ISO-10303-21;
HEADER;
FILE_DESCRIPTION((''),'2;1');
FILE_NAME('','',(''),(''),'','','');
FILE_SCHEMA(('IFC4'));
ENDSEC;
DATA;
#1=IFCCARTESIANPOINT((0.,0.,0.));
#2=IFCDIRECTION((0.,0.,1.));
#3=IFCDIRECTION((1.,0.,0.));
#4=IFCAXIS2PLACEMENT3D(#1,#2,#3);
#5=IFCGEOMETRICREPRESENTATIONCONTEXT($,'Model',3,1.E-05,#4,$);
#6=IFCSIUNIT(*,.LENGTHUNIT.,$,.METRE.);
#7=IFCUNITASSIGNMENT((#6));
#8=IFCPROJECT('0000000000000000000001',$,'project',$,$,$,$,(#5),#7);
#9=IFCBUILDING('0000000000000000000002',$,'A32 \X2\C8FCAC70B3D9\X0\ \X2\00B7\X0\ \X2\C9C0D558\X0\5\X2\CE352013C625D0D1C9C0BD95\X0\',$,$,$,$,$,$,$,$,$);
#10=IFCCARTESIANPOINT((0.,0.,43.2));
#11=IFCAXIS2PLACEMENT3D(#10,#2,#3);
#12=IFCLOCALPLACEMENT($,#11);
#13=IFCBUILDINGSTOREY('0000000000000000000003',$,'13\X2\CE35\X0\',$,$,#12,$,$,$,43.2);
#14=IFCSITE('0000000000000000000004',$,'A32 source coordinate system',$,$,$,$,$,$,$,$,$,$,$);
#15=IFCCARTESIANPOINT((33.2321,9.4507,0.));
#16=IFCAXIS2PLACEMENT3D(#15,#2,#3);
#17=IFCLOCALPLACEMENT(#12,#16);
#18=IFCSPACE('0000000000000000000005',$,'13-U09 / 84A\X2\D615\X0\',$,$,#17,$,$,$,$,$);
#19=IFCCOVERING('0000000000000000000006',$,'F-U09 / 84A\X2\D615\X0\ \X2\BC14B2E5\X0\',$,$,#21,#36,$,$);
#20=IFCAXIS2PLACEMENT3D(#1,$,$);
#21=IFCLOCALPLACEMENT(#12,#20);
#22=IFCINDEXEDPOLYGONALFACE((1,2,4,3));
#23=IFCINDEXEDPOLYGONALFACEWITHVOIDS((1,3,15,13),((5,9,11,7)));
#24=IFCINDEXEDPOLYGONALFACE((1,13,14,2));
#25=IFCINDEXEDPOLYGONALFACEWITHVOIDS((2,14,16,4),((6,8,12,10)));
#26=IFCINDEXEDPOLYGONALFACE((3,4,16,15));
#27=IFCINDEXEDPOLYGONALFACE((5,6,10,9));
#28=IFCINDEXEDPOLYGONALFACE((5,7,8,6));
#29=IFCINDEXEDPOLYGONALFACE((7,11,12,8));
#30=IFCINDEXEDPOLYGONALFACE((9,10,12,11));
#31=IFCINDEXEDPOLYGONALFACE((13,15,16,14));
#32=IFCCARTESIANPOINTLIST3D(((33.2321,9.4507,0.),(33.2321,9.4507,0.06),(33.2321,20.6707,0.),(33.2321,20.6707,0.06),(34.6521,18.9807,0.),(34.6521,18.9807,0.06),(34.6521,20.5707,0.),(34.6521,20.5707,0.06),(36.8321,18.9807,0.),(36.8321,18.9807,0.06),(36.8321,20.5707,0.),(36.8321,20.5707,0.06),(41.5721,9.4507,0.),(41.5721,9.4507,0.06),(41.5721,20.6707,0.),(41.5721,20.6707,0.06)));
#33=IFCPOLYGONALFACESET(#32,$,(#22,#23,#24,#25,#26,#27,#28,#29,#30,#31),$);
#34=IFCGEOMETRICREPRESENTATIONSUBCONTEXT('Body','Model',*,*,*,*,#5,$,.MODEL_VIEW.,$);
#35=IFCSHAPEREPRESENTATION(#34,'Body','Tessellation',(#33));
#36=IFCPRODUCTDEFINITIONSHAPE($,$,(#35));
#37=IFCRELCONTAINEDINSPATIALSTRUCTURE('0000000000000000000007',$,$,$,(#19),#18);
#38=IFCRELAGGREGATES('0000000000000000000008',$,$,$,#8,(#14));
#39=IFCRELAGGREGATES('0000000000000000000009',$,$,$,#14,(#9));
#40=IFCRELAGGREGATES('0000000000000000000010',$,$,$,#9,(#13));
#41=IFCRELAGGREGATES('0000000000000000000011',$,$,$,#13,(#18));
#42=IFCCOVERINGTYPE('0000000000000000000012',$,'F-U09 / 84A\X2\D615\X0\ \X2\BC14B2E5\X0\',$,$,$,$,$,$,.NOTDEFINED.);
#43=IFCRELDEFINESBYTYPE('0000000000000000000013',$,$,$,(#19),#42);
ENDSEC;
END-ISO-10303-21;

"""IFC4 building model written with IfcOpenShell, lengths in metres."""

from ifc_helpers import new_model, si_unit, frame, origin, origin_with_axes, place, context, subcontext, project, spatial, polyline, outline, extrude, source, transform, mapped, type_object, type_shapes, element, save


model = new_model("IFC4")

# Units and contexts
model_context = context("Model", 3, precision=1e-05, world=origin_with_axes())
body_context = subcontext(model_context, "Body", "Model", "MODEL_VIEW")
ifc_project = project(units=[si_unit("LENGTHUNIT", "METRE")], contexts=[model_context])

# Site, building, storey, space
storey_placement = place(None, frame((0.0, 0.0, 43.2), z_axis=(0.0, 0.0, 1.0), x_axis=(1.0, 0.0, 0.0)))
space_placement = place(storey_placement, frame((33.2321, 9.4507, 0.0), z_axis=(0.0, 0.0, 1.0), x_axis=(1.0, 0.0, 0.0)))
site = spatial("IfcSite", under=ifc_project, Name="A32 source coordinate system")
building = spatial("IfcBuilding", under=site, Name="A32 주거동 · 지하5층–옥탑지붕")
storey = spatial("IfcBuildingStorey", under=building, at=storey_placement, Name="13층", Elevation=43.2)
space = spatial("IfcSpace", under=storey, at=space_placement, Name="13-U09 / 84A형")

# Covering
covering_type_1 = type_object("IfcCoveringType", Name="F-U09 / 84A형 바닥", PredefinedType="NOTDEFINED")
shared_shape_1 = source(origin(), body_context, "Body", "SweptSolid", [
    extrude(outline(polyline([(0.0, 0.0), (0.0, 11.22), (8.34, 11.22), (8.34, 0.0), (0.0, 0.0)]), holes=[polyline([(1.42, 11.12), (1.42, 9.53), (3.6, 9.53), (3.6, 11.12), (1.42, 11.12)])]), origin(), (0.0, 0.0, 1.0), 0.06),
])
type_shapes(covering_type_1, [shared_shape_1])
covering_1_placement = place(space_placement, origin_with_axes())
element("IfcCovering", 1, at=covering_1_placement, inside=space, type_object=covering_type_1, Name="F-U09 / 84A형 바닥", context=body_context, shape_type="MappedRepresentation", body=[
    mapped(shared_shape_1, transform((0.0, 0.0, 0.0), scale=1.0)),
])

save(model, "model.ifc")
